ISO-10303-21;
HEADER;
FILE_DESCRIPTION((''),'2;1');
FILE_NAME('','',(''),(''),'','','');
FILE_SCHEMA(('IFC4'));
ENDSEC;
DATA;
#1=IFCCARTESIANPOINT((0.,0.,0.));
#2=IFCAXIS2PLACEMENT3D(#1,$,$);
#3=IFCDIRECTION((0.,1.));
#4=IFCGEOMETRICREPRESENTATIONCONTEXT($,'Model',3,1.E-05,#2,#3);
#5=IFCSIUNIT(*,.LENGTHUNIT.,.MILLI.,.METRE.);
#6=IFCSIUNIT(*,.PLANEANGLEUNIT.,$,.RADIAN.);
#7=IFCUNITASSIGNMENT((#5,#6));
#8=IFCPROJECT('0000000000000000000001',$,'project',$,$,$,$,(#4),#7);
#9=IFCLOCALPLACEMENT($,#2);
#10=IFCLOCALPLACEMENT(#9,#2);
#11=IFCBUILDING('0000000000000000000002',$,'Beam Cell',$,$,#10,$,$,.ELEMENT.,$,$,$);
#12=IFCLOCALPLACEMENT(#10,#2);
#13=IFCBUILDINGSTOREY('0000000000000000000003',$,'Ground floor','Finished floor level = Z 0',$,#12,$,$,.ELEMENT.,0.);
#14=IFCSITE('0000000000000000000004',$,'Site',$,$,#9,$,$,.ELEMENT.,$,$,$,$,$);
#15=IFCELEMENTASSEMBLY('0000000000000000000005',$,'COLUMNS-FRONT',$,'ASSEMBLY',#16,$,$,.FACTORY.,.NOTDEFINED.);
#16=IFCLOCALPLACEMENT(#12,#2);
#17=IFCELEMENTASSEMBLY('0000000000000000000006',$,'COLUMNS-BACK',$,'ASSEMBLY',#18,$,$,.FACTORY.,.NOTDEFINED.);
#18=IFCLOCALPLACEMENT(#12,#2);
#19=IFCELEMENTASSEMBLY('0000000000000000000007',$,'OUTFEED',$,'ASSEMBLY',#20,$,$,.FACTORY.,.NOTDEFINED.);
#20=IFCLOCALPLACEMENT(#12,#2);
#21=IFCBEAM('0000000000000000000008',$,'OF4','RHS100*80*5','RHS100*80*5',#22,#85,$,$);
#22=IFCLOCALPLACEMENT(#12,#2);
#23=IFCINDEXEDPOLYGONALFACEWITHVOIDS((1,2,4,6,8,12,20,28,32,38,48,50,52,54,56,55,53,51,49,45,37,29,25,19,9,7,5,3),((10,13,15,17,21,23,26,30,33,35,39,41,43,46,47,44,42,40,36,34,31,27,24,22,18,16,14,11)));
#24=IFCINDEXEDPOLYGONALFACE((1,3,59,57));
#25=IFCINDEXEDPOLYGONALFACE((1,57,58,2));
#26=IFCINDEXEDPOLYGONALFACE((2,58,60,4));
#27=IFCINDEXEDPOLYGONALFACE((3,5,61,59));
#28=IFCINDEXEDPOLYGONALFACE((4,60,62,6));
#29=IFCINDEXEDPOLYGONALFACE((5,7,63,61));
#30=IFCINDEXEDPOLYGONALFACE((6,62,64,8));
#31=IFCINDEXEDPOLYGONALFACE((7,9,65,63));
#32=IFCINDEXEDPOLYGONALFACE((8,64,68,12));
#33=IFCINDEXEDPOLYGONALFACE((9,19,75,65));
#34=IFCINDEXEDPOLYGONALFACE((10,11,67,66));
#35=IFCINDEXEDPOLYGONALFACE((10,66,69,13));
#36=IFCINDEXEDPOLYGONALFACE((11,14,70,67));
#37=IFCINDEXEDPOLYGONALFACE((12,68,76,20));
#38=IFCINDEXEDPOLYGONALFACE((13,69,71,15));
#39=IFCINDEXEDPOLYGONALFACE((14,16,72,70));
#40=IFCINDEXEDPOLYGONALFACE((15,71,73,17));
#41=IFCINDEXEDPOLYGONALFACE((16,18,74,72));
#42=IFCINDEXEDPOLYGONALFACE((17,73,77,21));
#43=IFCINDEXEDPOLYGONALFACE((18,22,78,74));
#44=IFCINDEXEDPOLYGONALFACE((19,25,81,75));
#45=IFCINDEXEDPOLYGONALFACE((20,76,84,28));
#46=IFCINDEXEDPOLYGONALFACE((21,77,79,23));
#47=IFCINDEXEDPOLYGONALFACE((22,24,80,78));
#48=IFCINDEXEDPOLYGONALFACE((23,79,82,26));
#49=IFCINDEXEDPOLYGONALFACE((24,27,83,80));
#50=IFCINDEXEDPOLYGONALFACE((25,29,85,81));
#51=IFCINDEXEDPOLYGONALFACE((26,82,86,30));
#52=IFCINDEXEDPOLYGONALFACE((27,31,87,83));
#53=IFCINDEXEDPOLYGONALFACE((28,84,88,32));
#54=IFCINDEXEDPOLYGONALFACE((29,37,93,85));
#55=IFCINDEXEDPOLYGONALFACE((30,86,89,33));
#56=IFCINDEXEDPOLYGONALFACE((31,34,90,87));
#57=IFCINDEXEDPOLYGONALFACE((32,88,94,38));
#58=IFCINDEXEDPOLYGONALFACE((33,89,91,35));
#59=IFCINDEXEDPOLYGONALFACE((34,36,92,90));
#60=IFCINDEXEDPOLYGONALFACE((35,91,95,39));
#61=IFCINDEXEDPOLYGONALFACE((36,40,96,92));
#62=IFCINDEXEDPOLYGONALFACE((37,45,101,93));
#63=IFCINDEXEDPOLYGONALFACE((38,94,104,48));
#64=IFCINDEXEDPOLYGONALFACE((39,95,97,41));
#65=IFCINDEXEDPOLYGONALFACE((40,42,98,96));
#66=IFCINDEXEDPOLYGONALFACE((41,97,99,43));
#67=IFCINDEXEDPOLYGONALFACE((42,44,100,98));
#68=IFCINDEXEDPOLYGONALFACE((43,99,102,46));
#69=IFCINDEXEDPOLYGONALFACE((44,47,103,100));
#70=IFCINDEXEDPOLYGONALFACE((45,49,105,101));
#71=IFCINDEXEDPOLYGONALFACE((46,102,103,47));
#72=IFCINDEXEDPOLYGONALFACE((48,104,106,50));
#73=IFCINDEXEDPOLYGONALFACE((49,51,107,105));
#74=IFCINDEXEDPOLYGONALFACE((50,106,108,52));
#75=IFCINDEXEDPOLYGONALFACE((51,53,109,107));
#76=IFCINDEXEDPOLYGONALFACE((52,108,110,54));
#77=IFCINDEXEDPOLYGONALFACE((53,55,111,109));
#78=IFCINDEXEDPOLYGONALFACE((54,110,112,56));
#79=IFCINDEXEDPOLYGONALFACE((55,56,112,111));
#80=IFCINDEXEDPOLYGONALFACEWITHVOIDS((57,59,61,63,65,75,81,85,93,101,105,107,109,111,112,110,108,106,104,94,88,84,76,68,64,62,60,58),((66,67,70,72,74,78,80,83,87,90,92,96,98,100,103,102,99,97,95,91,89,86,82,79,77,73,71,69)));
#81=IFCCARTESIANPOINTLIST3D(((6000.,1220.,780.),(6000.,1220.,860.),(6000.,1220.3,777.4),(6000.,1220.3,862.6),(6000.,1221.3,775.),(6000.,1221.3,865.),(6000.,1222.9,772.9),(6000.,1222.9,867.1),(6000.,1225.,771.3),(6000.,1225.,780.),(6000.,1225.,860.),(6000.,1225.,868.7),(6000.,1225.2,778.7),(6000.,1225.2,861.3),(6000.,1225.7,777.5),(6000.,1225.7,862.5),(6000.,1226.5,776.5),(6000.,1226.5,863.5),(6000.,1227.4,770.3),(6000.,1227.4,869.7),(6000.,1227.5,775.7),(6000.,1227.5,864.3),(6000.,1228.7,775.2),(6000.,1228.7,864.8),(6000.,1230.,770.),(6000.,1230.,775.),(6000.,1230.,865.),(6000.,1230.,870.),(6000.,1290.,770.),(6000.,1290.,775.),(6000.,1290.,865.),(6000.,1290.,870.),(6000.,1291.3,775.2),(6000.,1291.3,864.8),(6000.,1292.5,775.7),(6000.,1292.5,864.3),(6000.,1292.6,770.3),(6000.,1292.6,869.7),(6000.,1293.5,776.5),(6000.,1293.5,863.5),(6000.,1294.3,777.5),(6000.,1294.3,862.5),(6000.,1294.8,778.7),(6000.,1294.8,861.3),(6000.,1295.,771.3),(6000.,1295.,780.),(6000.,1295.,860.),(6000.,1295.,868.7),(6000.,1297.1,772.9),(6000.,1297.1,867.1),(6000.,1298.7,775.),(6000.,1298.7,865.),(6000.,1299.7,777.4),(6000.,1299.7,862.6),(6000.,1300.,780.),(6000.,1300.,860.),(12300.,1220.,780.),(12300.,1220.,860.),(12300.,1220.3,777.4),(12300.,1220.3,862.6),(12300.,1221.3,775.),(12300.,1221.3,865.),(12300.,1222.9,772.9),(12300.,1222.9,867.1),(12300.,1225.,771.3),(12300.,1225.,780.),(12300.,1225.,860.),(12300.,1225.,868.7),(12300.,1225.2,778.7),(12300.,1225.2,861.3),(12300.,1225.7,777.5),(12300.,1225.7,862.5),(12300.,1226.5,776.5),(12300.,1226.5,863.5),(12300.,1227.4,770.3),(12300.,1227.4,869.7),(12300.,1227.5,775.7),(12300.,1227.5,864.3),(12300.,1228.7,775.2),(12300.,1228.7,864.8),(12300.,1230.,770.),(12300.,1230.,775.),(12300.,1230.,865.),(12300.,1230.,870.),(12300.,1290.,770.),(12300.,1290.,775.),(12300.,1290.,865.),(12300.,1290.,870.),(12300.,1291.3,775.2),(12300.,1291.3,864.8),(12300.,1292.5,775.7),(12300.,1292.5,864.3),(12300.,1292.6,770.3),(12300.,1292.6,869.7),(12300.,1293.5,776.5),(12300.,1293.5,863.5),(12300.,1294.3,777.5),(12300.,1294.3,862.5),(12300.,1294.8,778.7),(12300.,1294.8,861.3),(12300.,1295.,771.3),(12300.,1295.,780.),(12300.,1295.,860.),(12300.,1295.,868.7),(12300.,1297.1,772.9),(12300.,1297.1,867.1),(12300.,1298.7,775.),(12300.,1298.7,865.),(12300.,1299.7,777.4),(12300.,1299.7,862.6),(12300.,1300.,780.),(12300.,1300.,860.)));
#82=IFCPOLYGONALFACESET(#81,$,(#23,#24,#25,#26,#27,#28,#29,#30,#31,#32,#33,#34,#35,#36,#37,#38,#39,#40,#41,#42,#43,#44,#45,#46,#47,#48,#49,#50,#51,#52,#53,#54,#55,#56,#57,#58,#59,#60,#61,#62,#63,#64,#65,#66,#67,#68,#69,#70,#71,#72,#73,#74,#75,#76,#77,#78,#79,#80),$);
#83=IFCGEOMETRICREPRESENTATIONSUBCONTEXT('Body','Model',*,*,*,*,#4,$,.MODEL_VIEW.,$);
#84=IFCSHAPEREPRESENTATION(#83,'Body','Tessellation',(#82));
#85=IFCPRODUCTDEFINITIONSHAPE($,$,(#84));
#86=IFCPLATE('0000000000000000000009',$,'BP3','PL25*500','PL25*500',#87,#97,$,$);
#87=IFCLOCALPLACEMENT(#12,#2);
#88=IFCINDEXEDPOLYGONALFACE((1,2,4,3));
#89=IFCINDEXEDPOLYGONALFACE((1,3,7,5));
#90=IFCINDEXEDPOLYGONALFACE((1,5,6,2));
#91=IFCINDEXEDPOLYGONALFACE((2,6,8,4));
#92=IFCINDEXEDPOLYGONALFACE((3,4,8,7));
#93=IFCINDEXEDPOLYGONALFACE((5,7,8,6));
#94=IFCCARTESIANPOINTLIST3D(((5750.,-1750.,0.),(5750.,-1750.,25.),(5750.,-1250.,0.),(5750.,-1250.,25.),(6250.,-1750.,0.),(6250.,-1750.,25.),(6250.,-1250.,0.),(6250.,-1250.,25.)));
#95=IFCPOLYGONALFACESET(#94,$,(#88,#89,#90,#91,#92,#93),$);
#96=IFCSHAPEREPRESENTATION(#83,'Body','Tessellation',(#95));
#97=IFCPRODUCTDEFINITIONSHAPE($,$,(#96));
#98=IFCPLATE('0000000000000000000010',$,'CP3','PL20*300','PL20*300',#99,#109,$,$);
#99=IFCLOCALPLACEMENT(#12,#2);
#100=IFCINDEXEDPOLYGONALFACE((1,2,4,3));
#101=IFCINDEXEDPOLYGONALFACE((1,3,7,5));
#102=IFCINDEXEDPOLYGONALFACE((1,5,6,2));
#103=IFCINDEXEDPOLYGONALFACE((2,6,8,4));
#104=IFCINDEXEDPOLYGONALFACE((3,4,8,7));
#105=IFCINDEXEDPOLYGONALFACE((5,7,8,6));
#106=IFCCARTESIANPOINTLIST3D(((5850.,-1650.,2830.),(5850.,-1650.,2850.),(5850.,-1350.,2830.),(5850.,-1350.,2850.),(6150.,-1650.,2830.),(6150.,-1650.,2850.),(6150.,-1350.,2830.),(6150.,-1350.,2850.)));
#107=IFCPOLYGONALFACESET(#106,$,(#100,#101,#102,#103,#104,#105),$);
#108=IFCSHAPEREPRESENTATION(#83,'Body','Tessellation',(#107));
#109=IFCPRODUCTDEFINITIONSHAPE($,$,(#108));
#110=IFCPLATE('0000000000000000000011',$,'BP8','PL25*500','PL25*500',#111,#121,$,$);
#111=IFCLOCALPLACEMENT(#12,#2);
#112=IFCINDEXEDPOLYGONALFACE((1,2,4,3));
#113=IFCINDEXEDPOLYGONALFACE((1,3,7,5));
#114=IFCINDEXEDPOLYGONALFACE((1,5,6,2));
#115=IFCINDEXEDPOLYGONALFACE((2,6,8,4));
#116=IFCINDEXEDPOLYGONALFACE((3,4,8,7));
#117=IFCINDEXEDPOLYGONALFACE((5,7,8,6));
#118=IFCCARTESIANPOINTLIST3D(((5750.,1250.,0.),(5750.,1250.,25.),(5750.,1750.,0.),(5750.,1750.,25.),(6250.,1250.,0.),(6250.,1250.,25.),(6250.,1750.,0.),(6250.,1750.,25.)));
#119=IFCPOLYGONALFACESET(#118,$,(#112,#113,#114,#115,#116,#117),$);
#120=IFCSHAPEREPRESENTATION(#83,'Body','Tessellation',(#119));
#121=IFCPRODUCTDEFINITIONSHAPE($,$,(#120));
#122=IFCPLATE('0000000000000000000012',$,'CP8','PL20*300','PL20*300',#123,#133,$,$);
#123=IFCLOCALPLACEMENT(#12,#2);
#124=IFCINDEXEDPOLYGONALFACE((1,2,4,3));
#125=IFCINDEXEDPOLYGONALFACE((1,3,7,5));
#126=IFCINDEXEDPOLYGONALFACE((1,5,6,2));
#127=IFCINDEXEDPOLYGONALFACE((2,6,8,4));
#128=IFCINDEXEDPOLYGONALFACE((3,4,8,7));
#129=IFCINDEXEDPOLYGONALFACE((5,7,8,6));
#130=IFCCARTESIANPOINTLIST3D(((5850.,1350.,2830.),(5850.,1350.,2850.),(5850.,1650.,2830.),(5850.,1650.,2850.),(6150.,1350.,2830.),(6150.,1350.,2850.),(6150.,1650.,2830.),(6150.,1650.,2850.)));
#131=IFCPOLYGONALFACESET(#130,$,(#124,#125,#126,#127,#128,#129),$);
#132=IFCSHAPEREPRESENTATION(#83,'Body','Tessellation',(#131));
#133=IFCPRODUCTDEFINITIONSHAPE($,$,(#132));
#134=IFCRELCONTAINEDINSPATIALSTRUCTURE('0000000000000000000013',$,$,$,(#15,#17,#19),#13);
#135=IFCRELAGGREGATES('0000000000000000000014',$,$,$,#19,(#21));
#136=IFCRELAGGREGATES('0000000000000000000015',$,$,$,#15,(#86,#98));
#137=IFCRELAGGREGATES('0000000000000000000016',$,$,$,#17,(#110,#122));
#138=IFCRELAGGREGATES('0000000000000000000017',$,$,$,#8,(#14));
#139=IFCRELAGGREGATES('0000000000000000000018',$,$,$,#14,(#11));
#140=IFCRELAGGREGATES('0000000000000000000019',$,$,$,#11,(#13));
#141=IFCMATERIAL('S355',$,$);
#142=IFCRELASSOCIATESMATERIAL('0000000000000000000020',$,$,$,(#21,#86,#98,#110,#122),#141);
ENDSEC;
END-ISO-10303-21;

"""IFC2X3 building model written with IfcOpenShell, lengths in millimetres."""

from ifc_helpers import new_model, si_unit, direction, frame, origin, origin_2d, place, context, subcontext, project, spatial, rectangle, hollow_rectangle, extrude, material, element, aggregate, save


model = new_model("IFC2X3")

# Units and contexts
model_context = context("Model", 3, precision=1e-05, world=origin(), true_north=direction((0.0, 1.0)))
body_context = subcontext(model_context, "Body", "Model", "MODEL_VIEW")
ifc_project = project(units=[si_unit("LENGTHUNIT", "METRE", prefix="MILLI"), si_unit("PLANEANGLEUNIT", "RADIAN")], contexts=[model_context])

# Site, building, storey
site_placement = place(None, origin())
site = spatial("IfcSite", under=ifc_project, at=site_placement, Name="Site", CompositionType="ELEMENT")
building_placement = place(site_placement, origin())
building = spatial("IfcBuilding", under=site, at=building_placement, Name="Beam Cell", CompositionType="ELEMENT")
storey_placement = place(building_placement, origin())
storey = spatial("IfcBuildingStorey", under=building, at=storey_placement, Name="Ground floor", Description="Finished floor level = Z 0", CompositionType="ELEMENT", Elevation=0.0)

# Element assemblies
assembly_1_placement = place(storey_placement, origin())
assembly_1 = element("IfcElementAssembly", 1, at=assembly_1_placement, inside=storey, Name="COLUMNS-FRONT", ObjectType="ASSEMBLY", AssemblyPlace="FACTORY", PredefinedType="NOTDEFINED")
ifc_material = material(Name="S355")
assembly_2_placement = place(storey_placement, origin())
assembly_2 = element("IfcElementAssembly", 2, at=assembly_2_placement, inside=storey, Name="COLUMNS-BACK", ObjectType="ASSEMBLY", AssemblyPlace="FACTORY", PredefinedType="NOTDEFINED")

# Element assembly
assembly_3_placement = place(storey_placement, origin())
assembly_3 = element("IfcElementAssembly", 3, at=assembly_3_placement, inside=storey, Name="OUTFEED", ObjectType="ASSEMBLY", AssemblyPlace="FACTORY", PredefinedType="NOTDEFINED")

# Beam
beam_1_placement = place(storey_placement, frame((6000.0, 1260.0, 820.0), z_axis=(1.0, 0.0, 0.0), x_axis=(0.0, 1.0, 0.0)))
beam_1 = element("IfcBeam", 4, at=beam_1_placement, material=ifc_material, Name="OF4", Description="RHS100*80*5", ObjectType="RHS100*80*5", context=body_context, shape_type="SweptSolid", body=[
    extrude(hollow_rectangle(XDim=80.0, YDim=100.0, WallThickness=5.0, InnerFilletRadius=5.0, OuterFilletRadius=10.0, at=origin_2d()), origin(), (0.0, 0.0, 1.0), 6300.0),
])
aggregate(assembly_3, [beam_1])

# Plates
plate_1_placement = place(storey_placement, frame((6000.0, -1500.0, 0.0), z_axis=(0.0, 0.0, 1.0), x_axis=(1.0, 0.0, 0.0)))
plate_1 = element("IfcPlate", 5, at=plate_1_placement, material=ifc_material, Name="BP3", Description="PL25*500", ObjectType="PL25*500", context=body_context, shape_type="SweptSolid", body=[
    extrude(rectangle(XDim=500.0, YDim=500.0, at=origin_2d()), origin(), (0.0, 0.0, 1.0), 25.0),
])
plate_2_placement = place(storey_placement, frame((6000.0, -1500.0, 2830.0), z_axis=(0.0, 0.0, 1.0), x_axis=(1.0, 0.0, 0.0)))
plate_2 = element("IfcPlate", 6, at=plate_2_placement, material=ifc_material, Name="CP3", Description="PL20*300", ObjectType="PL20*300", context=body_context, shape_type="SweptSolid", body=[
    extrude(rectangle(XDim=300.0, YDim=300.0, at=origin_2d()), origin(), (0.0, 0.0, 1.0), 20.0),
])
aggregate(assembly_1, [plate_1, plate_2])
plate_3_placement = place(storey_placement, frame((6000.0, 1500.0, 0.0), z_axis=(0.0, 0.0, 1.0), x_axis=(1.0, 0.0, 0.0)))
plate_3 = element("IfcPlate", 7, at=plate_3_placement, material=ifc_material, Name="BP8", Description="PL25*500", ObjectType="PL25*500", context=body_context, shape_type="SweptSolid", body=[
    extrude(rectangle(XDim=500.0, YDim=500.0, at=origin_2d()), origin(), (0.0, 0.0, 1.0), 25.0),
])
plate_4_placement = place(storey_placement, frame((6000.0, 1500.0, 2830.0), z_axis=(0.0, 0.0, 1.0), x_axis=(1.0, 0.0, 0.0)))
plate_4 = element("IfcPlate", 8, at=plate_4_placement, material=ifc_material, Name="CP8", Description="PL20*300", ObjectType="PL20*300", context=body_context, shape_type="SweptSolid", body=[
    extrude(rectangle(XDim=300.0, YDim=300.0, at=origin_2d()), origin(), (0.0, 0.0, 1.0), 20.0),
])
aggregate(assembly_2, [plate_3, plate_4])

save(model, "model.ifc")
